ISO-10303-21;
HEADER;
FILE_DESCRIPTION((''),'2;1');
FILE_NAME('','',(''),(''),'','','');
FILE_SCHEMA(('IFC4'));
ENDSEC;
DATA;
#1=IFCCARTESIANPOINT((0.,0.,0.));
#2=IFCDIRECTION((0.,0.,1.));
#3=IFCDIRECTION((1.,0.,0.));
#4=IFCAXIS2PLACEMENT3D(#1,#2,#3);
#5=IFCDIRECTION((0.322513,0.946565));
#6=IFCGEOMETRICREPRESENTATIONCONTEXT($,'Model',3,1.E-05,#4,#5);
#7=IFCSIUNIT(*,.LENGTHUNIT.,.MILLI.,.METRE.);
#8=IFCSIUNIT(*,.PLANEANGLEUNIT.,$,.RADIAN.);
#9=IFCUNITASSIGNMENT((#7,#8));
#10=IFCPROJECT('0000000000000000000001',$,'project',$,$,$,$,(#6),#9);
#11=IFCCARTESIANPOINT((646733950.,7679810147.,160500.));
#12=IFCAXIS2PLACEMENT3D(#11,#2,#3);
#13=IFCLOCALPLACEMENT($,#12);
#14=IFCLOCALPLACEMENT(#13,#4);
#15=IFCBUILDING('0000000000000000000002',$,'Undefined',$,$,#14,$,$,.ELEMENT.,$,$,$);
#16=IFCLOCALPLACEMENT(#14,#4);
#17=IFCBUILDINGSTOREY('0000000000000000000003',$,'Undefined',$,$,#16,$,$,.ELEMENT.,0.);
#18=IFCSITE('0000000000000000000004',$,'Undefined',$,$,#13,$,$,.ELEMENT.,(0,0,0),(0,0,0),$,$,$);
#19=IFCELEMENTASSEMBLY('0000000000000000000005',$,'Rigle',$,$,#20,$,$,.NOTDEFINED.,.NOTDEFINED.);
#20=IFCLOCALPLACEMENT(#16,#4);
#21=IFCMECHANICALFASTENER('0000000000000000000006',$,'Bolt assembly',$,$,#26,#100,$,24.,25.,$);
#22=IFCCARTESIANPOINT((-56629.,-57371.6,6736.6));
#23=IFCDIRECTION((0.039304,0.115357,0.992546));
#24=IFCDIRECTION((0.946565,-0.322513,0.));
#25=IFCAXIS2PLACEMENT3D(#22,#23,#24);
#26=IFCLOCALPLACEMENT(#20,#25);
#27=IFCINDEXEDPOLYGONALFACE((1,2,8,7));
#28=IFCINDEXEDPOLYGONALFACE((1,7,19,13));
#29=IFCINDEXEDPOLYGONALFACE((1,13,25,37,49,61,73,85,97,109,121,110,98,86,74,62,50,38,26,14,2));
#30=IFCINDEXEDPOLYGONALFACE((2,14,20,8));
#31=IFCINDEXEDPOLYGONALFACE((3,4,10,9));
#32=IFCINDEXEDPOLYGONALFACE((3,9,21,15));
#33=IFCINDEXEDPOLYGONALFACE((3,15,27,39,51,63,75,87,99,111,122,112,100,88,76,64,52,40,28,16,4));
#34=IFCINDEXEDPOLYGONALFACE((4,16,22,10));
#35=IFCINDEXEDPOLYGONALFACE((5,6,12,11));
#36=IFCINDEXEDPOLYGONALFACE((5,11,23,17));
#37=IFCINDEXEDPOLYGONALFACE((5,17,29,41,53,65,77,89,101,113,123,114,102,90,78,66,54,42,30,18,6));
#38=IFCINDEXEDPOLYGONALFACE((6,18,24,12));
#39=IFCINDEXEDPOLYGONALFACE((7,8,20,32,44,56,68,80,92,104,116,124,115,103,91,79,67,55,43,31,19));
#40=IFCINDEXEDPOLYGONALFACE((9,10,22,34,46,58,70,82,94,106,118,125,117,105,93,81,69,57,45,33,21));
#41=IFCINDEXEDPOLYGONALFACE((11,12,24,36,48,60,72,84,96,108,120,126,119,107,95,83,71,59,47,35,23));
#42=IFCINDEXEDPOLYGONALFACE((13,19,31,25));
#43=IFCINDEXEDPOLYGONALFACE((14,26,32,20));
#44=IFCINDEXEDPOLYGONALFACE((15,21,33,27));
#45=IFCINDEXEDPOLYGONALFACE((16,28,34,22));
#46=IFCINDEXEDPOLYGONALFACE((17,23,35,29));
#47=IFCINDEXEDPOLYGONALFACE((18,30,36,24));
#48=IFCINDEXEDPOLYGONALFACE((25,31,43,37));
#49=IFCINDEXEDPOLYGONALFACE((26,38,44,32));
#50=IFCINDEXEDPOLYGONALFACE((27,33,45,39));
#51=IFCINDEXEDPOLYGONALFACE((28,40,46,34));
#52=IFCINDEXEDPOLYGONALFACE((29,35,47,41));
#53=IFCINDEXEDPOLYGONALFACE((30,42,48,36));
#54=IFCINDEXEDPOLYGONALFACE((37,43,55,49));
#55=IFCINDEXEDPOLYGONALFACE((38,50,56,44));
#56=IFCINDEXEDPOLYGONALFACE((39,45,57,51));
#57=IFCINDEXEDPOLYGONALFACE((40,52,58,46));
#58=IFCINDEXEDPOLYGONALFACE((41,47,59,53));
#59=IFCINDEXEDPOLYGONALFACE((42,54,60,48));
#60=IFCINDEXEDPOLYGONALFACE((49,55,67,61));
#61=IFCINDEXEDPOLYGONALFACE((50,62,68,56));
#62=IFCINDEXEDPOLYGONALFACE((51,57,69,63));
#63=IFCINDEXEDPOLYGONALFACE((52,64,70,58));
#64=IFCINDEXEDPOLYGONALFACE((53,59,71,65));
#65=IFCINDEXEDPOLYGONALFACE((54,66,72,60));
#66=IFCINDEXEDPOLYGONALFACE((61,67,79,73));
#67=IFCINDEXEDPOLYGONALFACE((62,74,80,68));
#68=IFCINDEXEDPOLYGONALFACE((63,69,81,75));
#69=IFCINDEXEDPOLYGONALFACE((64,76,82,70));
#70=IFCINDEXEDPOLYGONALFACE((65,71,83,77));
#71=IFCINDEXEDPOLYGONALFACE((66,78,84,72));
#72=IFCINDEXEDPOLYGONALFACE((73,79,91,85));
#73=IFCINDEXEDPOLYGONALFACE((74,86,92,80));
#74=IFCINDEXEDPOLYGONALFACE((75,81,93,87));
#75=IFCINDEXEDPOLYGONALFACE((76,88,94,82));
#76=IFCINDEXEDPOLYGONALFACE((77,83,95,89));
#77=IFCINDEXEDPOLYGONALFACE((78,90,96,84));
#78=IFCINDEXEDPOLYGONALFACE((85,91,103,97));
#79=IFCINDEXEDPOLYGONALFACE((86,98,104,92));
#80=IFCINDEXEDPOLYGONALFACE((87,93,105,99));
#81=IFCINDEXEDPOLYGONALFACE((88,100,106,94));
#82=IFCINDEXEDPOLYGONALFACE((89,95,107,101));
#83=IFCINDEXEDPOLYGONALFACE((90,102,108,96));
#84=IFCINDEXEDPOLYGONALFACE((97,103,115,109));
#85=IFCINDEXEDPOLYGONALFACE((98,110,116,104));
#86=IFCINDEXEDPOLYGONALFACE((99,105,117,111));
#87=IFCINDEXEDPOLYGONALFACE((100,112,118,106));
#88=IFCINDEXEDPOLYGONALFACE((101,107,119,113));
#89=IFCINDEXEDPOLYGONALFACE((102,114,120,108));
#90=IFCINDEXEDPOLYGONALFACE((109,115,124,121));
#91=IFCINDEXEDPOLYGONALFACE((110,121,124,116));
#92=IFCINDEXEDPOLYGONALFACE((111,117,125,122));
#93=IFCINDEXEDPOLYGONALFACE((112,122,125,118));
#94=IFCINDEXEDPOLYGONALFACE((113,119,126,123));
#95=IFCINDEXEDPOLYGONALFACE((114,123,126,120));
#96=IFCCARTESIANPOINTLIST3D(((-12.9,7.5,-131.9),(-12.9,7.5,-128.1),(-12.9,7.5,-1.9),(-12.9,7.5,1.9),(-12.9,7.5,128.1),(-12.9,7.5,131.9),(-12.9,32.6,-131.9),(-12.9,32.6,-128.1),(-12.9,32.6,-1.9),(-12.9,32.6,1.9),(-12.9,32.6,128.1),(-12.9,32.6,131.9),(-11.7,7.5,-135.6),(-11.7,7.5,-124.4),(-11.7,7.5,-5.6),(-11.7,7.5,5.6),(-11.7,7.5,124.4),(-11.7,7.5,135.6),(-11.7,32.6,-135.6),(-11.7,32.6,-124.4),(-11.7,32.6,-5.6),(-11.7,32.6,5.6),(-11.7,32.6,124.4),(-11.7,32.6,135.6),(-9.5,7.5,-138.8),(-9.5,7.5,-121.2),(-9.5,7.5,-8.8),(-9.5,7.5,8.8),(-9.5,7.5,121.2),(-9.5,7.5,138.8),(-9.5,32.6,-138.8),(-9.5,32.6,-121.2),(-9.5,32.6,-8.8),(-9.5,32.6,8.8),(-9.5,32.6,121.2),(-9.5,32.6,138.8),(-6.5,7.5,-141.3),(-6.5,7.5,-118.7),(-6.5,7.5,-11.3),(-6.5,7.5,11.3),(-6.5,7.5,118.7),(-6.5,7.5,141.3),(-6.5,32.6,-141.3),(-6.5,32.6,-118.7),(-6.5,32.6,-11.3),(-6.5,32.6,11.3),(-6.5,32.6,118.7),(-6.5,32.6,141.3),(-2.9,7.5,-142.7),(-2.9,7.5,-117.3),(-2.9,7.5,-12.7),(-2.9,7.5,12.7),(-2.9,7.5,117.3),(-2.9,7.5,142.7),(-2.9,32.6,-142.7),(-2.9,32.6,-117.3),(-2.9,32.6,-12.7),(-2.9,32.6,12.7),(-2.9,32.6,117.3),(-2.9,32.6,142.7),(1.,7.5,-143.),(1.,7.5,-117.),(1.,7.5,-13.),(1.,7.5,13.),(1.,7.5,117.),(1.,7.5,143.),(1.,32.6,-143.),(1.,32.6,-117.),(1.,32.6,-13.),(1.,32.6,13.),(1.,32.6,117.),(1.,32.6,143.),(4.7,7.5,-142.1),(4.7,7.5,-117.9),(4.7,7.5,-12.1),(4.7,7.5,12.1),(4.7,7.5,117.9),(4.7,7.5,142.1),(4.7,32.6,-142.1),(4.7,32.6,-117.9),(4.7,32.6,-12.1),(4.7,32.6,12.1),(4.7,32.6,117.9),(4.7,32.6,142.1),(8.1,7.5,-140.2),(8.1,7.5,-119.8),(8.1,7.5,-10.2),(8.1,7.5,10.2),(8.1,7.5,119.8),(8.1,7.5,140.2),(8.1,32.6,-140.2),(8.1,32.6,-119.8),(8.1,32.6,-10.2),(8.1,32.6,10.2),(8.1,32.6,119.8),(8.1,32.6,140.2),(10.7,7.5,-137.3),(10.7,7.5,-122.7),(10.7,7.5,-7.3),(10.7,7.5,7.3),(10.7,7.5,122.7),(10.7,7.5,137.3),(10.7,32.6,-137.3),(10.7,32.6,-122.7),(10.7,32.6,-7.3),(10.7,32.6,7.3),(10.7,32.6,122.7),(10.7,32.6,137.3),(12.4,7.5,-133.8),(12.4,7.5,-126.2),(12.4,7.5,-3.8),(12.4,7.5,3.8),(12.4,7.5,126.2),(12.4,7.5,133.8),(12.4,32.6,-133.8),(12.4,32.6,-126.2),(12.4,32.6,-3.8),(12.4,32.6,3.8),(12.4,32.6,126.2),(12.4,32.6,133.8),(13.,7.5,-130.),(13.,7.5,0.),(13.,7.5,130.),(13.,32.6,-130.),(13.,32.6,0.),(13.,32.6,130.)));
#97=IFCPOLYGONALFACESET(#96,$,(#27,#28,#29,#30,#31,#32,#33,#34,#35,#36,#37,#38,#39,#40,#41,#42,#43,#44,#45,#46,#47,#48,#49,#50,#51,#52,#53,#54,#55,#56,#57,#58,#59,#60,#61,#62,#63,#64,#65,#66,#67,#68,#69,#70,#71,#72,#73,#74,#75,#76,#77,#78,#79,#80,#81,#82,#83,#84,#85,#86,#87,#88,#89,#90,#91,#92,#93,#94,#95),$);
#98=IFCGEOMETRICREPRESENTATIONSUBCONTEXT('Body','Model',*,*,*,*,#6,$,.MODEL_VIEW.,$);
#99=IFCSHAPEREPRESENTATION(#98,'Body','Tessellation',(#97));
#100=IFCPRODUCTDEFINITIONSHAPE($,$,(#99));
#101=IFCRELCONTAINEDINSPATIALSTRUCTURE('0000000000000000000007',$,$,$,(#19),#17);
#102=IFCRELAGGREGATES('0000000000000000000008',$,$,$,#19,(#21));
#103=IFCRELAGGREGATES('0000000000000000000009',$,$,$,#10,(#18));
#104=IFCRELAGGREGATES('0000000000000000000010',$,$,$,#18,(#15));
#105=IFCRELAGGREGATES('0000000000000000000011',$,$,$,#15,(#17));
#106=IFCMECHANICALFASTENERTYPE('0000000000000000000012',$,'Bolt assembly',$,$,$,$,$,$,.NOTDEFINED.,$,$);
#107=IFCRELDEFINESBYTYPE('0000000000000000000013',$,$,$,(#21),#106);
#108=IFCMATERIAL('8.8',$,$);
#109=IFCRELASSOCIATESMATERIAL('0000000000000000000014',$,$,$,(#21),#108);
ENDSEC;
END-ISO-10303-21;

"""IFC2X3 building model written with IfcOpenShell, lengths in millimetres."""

from ifc_helpers import new_model, si_unit, direction, frame, origin_with_axes, origin_2d_with_axis, place, context, subcontext, project, spatial, circle, extrude, source, transform, mapped, material, type_object, element, aggregate, save


model = new_model("IFC2X3")

# Units and contexts
model_context = context("Model", 3, precision=1e-05, world=origin_with_axes(), true_north=direction((0.322513, 0.946565)))
body_context = subcontext(model_context, "Body", "Model", "MODEL_VIEW")
ifc_project = project(units=[si_unit("LENGTHUNIT", "METRE", prefix="MILLI"), si_unit("PLANEANGLEUNIT", "RADIAN")], contexts=[model_context])

# Site, building, storey
site_placement = place(None, frame((646733950.0, 7679810147.0, 160500.0), z_axis=(0.0, 0.0, 1.0), x_axis=(1.0, 0.0, 0.0)))
site = spatial("IfcSite", under=ifc_project, at=site_placement, Name="Undefined", CompositionType="ELEMENT", RefLatitude=(0, 0, 0), RefLongitude=(0, 0, 0))
building_placement = place(site_placement, origin_with_axes())
building = spatial("IfcBuilding", under=site, at=building_placement, Name="Undefined", CompositionType="ELEMENT")
storey_placement = place(building_placement, origin_with_axes())
storey = spatial("IfcBuildingStorey", under=building, at=storey_placement, Name="Undefined", CompositionType="ELEMENT", Elevation=0.0)

# Element assembly
assembly_1_placement = place(storey_placement, origin_with_axes())
assembly_1 = element("IfcElementAssembly", 1, at=assembly_1_placement, inside=storey, Name="Rigle", AssemblyPlace="NOTDEFINED", PredefinedType="NOTDEFINED")

# Mechanical fastener
ifc_material_1 = material(Name="8.8")
mechanical_fastener_type = type_object("IfcMechanicalFastenerType", Name="Bolt assembly")
shared_shape_1 = source(origin_with_axes(), body_context, "Body", "SweptSolid", [
    extrude(circle(Radius=13.0, at=origin_2d_with_axis()), frame((0.0, 7.5, 0.0), z_axis=(0.0, 1.0, 0.0), x_axis=(1.0, 0.0, 0.0)), (0.0, 0.0, 1.0), 25.1),
])
mechanical_fastener_1_placement = place(assembly_1_placement, frame((-56629.0, -57371.6, 6736.6), z_axis=(0.039304, 0.115357, 0.992546), x_axis=(0.946565, -0.322513, 0.0)))
mechanical_fastener_1 = element("IfcMechanicalFastener", 2, at=mechanical_fastener_1_placement, type_object=mechanical_fastener_type, material=ifc_material_1, Name="Bolt assembly", NominalDiameter=24.0, NominalLength=25.0, context=body_context, shape_type="MappedRepresentation", body=[
    mapped(shared_shape_1, transform((0.0, 0.0, -130.0))),
    mapped(shared_shape_1, transform((0.0, 0.0, 0.0))),
    mapped(shared_shape_1, transform((0.0, 0.0, 130.0))),
])
aggregate(assembly_1, [mechanical_fastener_1])

save(model, "model.ifc")
